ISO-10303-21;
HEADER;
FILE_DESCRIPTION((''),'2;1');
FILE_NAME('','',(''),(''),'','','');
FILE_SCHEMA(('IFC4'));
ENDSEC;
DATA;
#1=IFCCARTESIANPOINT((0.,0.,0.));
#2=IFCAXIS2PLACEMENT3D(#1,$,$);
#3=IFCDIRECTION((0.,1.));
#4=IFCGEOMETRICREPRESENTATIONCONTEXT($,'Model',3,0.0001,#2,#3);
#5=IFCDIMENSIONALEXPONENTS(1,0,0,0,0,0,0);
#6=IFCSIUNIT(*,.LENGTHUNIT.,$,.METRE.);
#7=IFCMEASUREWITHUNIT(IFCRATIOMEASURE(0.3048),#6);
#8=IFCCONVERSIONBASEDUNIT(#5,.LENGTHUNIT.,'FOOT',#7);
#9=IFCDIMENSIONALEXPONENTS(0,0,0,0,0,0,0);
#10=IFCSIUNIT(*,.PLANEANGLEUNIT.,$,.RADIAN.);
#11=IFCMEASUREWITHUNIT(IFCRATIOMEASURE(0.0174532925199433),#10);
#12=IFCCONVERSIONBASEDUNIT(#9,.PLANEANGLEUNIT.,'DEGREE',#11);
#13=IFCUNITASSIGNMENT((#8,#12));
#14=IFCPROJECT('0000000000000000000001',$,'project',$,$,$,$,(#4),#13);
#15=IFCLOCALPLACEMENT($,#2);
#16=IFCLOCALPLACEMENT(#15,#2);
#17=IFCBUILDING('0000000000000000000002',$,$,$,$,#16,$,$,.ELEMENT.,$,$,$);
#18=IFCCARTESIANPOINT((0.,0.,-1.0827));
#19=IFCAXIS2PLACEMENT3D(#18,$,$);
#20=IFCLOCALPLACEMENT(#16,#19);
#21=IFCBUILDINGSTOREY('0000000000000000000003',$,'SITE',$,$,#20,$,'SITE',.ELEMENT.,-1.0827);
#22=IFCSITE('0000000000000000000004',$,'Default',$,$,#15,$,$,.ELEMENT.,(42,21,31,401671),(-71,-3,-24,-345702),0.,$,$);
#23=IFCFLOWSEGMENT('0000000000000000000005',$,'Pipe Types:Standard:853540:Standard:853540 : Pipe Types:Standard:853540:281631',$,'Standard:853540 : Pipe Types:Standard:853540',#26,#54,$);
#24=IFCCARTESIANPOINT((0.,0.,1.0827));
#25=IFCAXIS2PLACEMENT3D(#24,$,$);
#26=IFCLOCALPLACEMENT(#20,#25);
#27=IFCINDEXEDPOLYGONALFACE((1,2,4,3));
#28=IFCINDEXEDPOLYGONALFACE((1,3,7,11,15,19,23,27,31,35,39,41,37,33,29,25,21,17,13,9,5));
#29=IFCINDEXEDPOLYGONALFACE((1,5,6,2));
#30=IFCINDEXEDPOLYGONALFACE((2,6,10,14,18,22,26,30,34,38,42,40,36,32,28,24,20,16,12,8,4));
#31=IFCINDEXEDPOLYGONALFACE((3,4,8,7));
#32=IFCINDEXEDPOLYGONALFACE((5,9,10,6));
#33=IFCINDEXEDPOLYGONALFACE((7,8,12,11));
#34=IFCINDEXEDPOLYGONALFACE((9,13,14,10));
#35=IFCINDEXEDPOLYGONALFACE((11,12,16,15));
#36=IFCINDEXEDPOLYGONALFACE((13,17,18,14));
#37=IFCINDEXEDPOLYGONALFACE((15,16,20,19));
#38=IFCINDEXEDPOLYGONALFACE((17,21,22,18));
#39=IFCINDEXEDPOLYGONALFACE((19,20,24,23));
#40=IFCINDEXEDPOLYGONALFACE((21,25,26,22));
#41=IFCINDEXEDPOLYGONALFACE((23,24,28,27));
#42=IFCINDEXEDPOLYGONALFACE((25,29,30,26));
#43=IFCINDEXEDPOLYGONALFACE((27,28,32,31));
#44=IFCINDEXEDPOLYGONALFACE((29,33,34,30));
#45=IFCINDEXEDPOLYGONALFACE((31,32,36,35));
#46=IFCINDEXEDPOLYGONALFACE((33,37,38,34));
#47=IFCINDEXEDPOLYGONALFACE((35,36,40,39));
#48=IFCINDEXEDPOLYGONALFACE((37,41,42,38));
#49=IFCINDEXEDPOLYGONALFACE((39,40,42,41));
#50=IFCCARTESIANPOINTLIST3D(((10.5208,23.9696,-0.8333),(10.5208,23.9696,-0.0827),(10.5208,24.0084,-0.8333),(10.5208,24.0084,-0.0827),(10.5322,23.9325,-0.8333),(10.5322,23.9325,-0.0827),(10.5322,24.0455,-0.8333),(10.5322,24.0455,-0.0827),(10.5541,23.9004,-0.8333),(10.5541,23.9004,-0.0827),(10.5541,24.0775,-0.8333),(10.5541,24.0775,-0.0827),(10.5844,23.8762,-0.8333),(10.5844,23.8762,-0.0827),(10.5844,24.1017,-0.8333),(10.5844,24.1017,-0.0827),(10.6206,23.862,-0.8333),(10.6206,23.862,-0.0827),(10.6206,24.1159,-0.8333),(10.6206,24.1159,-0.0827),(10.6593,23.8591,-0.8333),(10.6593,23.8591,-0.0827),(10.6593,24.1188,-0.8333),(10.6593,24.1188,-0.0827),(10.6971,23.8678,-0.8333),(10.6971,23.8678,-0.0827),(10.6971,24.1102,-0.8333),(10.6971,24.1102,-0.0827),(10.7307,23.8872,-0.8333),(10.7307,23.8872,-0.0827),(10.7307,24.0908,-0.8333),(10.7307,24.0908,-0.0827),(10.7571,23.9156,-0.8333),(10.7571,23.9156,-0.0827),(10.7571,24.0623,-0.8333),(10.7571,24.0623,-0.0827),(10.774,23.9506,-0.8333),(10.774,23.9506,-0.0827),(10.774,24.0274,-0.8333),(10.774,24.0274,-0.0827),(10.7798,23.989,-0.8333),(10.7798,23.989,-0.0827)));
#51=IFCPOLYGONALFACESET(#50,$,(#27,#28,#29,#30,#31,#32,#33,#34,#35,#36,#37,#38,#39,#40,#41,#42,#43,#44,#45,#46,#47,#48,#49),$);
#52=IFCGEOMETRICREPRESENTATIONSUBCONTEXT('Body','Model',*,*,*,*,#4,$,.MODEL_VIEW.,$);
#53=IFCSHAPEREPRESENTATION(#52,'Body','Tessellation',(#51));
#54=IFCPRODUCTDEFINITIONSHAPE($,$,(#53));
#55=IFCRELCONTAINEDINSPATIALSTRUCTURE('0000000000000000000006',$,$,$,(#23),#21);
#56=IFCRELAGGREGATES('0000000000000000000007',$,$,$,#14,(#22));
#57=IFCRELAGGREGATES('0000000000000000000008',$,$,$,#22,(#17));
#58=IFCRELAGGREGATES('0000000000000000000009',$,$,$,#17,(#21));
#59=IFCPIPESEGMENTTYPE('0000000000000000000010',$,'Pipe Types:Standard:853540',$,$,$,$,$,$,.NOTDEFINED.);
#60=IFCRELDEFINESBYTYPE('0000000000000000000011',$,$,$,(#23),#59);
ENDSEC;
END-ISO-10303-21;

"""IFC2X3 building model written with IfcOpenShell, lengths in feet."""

from ifc_helpers import new_model, entity, si_unit, converted_unit, direction, frame, origin, origin_2d_with_axis, place, context, subcontext, project, spatial, circle, extrude, source, transform, mapped, type_object, type_shapes, element, save


model = new_model("IFC2X3")

# Units and contexts
model_context = context("Model", 3, precision=0.0001, world=origin(), true_north=direction((0.0, 1.0)))
body_context = subcontext(model_context, "Body", "Model", "MODEL_VIEW")
ifc_project = project(units=[converted_unit("LENGTHUNIT", "FOOT", entity("IfcRatioMeasure", 0.3048), si_unit("LENGTHUNIT", "METRE"), dimensions=[1, 0, 0, 0, 0, 0, 0]), converted_unit("PLANEANGLEUNIT", "DEGREE", entity("IfcRatioMeasure", 0.0174532925199433), si_unit("PLANEANGLEUNIT", "RADIAN"), dimensions=[0, 0, 0, 0, 0, 0, 0])], contexts=[model_context])

# Site, building, storey
site_placement = place(None, origin())
site = spatial("IfcSite", under=ifc_project, at=site_placement, Name="Default", CompositionType="ELEMENT", RefLatitude=(42, 21, 31, 401671), RefLongitude=(-71, -3, -24, -345702), RefElevation=0.0)
building_placement = place(site_placement, origin())
building = spatial("IfcBuilding", under=site, at=building_placement, CompositionType="ELEMENT")
storey_placement = place(building_placement, frame((0.0, 0.0, -1.0827)))
storey = spatial("IfcBuildingStorey", under=building, at=storey_placement, Name="SITE", LongName="SITE", CompositionType="ELEMENT", Elevation=-1.0827)

# Flow segment
pipe_segment_type_1 = type_object("IfcPipeSegmentType", Name="Pipe Types:Standard:853540", PredefinedType="NOTDEFINED")
shared_shape_1 = source(origin(), body_context, "Body", "SweptSolid", [
    extrude(circle(Radius=0.1302, at=origin_2d_with_axis()), frame((10.6495, 23.989, -0.8333)), (0.0, 0.0, 1.0), 0.7507),
])
type_shapes(pipe_segment_type_1, [shared_shape_1])
flow_segment_1_placement = place(storey_placement, frame((0.0, 0.0, 1.0827)))
element("IfcFlowSegment", 1, at=flow_segment_1_placement, inside=storey, type_object=pipe_segment_type_1, Name="Pipe Types:Standard:853540:Standard:853540 : Pipe Types:Standard:853540:281631", ObjectType="Standard:853540 : Pipe Types:Standard:853540", context=body_context, shape_type="MappedRepresentation", body=[
    mapped(shared_shape_1, transform((0.0, 0.0, 0.0), scale=1.0)),
])

save(model, "model.ifc")
